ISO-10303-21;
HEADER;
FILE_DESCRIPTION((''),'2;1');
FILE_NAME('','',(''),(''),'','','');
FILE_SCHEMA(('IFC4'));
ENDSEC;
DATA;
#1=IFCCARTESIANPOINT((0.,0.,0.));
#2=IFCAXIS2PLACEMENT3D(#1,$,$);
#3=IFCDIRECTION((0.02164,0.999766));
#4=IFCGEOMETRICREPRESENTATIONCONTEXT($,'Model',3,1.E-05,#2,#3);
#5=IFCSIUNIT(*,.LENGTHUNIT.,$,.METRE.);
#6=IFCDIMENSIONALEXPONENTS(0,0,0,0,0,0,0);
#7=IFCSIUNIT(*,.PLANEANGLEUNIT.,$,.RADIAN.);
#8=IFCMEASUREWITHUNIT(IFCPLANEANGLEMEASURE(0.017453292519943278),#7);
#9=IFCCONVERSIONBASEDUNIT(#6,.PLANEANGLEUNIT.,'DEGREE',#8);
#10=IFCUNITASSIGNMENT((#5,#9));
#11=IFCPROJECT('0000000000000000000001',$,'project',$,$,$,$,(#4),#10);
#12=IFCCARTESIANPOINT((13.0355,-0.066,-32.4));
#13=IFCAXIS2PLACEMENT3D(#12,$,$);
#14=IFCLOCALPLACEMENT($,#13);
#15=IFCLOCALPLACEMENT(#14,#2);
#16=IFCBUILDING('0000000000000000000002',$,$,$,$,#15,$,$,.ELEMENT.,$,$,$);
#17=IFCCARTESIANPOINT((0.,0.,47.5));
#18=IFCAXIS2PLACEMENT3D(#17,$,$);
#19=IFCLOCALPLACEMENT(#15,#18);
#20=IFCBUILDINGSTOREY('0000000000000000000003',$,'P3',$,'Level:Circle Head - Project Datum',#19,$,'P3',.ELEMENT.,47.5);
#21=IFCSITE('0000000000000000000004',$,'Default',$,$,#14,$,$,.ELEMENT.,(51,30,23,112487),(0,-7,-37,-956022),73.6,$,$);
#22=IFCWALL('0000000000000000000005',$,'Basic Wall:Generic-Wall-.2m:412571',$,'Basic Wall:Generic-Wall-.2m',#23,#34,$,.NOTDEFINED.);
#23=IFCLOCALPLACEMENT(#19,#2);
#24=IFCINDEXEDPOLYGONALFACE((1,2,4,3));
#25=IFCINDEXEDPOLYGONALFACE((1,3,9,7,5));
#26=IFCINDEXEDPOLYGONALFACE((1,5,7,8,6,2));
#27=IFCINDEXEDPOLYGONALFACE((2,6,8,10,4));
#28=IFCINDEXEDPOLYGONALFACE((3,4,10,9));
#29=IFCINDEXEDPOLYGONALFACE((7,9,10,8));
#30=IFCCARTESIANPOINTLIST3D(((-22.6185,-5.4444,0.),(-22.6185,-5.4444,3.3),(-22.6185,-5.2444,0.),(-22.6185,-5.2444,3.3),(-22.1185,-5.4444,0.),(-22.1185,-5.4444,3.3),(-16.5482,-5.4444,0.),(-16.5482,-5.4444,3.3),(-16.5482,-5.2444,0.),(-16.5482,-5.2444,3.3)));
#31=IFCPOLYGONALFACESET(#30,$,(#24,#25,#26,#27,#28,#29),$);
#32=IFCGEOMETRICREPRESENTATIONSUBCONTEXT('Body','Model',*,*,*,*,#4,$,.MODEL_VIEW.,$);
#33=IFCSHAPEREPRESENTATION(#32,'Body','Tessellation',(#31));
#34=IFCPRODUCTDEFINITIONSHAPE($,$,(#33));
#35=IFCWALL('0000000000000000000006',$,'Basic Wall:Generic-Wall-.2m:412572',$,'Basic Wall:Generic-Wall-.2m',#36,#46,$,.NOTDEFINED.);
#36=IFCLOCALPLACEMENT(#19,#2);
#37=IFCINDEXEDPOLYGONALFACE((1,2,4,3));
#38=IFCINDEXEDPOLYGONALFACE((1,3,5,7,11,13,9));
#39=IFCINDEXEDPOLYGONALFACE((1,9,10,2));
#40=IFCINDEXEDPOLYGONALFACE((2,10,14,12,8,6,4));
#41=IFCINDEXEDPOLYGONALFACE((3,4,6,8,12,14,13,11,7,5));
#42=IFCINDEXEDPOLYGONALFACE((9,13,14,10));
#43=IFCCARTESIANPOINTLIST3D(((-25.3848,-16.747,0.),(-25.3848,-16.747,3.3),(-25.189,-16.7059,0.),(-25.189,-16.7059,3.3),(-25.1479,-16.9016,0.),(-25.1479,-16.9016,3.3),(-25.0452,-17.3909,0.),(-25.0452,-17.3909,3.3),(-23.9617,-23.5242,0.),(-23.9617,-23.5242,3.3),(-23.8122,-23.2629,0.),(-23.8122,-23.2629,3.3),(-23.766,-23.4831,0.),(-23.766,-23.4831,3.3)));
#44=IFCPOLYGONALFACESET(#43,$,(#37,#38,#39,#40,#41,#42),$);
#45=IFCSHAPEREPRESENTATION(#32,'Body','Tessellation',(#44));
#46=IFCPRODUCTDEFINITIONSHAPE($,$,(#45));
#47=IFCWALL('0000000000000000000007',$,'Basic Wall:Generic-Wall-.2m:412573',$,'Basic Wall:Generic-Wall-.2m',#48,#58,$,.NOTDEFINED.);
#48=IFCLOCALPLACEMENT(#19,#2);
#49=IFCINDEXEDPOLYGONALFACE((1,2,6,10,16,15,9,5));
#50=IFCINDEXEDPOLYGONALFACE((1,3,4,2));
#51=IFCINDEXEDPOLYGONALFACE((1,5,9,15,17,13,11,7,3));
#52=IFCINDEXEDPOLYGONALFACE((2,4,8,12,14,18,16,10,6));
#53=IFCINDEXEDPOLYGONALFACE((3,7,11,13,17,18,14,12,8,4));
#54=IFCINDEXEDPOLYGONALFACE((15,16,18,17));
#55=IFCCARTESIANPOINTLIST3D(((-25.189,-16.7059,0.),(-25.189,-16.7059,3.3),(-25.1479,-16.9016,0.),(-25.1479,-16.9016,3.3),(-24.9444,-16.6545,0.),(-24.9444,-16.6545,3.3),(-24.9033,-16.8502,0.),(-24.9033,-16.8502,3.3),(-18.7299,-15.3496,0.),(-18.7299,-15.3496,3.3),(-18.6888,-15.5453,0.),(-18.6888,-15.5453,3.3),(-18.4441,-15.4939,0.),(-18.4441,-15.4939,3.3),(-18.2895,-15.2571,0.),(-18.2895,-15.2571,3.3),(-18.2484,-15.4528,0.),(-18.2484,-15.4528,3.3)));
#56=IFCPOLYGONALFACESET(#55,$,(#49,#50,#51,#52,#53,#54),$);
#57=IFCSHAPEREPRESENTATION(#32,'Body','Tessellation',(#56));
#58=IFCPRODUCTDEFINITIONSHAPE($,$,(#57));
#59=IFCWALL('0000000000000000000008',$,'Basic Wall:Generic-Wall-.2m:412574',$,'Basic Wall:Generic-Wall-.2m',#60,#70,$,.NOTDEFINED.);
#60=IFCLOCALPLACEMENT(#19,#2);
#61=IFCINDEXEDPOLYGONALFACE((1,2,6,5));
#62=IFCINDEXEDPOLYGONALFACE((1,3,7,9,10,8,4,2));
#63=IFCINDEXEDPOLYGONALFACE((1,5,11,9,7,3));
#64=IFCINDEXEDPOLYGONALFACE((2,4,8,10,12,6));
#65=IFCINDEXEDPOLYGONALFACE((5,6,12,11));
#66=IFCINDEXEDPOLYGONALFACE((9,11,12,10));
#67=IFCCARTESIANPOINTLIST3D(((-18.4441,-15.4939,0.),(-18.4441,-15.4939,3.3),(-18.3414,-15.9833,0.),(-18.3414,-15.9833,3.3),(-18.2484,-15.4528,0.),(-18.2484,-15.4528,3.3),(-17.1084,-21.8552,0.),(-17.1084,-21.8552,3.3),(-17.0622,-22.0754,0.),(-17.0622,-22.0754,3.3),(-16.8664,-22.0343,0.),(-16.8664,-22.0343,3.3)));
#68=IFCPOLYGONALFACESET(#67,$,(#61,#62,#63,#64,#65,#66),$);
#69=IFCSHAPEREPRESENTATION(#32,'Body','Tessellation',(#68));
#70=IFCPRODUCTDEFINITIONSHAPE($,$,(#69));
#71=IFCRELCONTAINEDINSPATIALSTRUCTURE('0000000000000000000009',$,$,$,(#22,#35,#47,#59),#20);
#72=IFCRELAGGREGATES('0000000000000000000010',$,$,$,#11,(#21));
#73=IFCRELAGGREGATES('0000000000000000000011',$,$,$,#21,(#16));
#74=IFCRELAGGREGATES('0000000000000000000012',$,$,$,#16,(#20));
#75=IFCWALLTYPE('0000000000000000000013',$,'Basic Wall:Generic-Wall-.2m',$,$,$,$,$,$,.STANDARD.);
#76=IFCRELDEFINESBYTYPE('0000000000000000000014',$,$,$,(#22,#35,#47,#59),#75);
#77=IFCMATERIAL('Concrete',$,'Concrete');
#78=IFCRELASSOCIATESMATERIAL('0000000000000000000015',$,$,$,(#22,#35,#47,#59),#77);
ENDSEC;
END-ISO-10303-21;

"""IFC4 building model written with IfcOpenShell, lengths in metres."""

from ifc_helpers import new_model, entity, si_unit, converted_unit, direction, frame, origin, place, context, subcontext, project, spatial, indexed_curve, outline, extrude, material, type_object, element, save


model = new_model("IFC4")

# Units and contexts
model_context = context("Model", 3, precision=1e-05, world=origin(), true_north=direction((0.02164, 0.999766)))
body_context = subcontext(model_context, "Body", "Model", "MODEL_VIEW")
ifc_project = project(units=[si_unit("LENGTHUNIT", "METRE"), converted_unit("PLANEANGLEUNIT", "DEGREE", entity("IfcPlaneAngleMeasure", 0.017453292519943278), si_unit("PLANEANGLEUNIT", "RADIAN"), dimensions=[0, 0, 0, 0, 0, 0, 0])], contexts=[model_context])

# Site, building, storey
site_placement = place(None, frame((13.0355, -0.066, -32.4)))
site = spatial("IfcSite", under=ifc_project, at=site_placement, Name="Default", CompositionType="ELEMENT", RefLatitude=(51, 30, 23, 112487), RefLongitude=(0, -7, -37, -956022), RefElevation=73.6)
building_placement = place(site_placement, origin())
building = spatial("IfcBuilding", under=site, at=building_placement, CompositionType="ELEMENT")
storey_placement = place(building_placement, frame((0.0, 0.0, 47.5)))
storey = spatial("IfcBuildingStorey", under=building, at=storey_placement, Name="P3", ObjectType="Level:Circle Head - Project Datum", LongName="P3", CompositionType="ELEMENT", Elevation=47.5)

# Shared definitions
ifc_material = material(Name="Concrete", Category="Concrete")

# Walls
wall_type_1 = type_object("IfcWallType", Name="Basic Wall:Generic-Wall-.2m", PredefinedType="STANDARD")
wall_1_placement = place(storey_placement, frame((-22.6185, -5.3444, 0.0)))
element("IfcWall", 1, at=wall_1_placement, inside=storey, type_object=wall_type_1, material=ifc_material, Name="Basic Wall:Generic-Wall-.2m:412571", ObjectType="Basic Wall:Generic-Wall-.2m", PredefinedType="NOTDEFINED", context=body_context, shape_type="SweptSolid", body=[
    extrude(outline(indexed_curve([(6.0702, -0.1), (6.0702, 0.1), (0.0, 0.1), (0.0, -0.1), (0.5, -0.1), (6.0702, -0.1)], self_intersect=False)), origin(), (0.0, 0.0, 1.0), 3.3),
])
wall_2_placement = place(storey_placement, frame((-23.8638, -23.5036, 0.0), z_axis=(0.0, 0.0, 1.0), x_axis=(-0.2055, 0.978657, 0.0)))
element("IfcWall", 2, at=wall_2_placement, inside=storey, type_object=wall_type_1, material=ifc_material, Name="Basic Wall:Generic-Wall-.2m:412572", ObjectType="Basic Wall:Generic-Wall-.2m", PredefinedType="NOTDEFINED", context=body_context, shape_type="SweptSolid", body=[
    extrude(outline(indexed_curve([(6.925, -0.1), (6.925, 0.1), (0.0, 0.1), (0.0, -0.1), (0.225, -0.1), (6.225, -0.1), (6.725, -0.1), (6.925, -0.1)], self_intersect=False)), origin(), (0.0, 0.0, 1.0), 3.3),
])
wall_3_placement = place(storey_placement, frame((-25.1685, -16.8038, 0.0), z_axis=(0.0, 0.0, 1.0), x_axis=(0.978657, 0.2055, 0.0)))
element("IfcWall", 3, at=wall_3_placement, inside=storey, type_object=wall_type_1, material=ifc_material, Name="Basic Wall:Generic-Wall-.2m:412573", ObjectType="Basic Wall:Generic-Wall-.2m", PredefinedType="NOTDEFINED", context=body_context, shape_type="SweptSolid", body=[
    extrude(outline(indexed_curve([(7.05, -0.1), (7.05, 0.1), (6.6, 0.1), (0.25, 0.1), (0.0, 0.1), (0.0, -0.1), (0.25, -0.1), (6.6, -0.1), (6.85, -0.1), (7.05, -0.1)], self_intersect=False)), origin(), (0.0, 0.0, 1.0), 3.3),
])
wall_4_placement = place(storey_placement, frame((-18.3463, -15.4734, 0.0), z_axis=(0.0, 0.0, 1.0), x_axis=(0.2055, -0.978657, 0.0)))
element("IfcWall", 4, at=wall_4_placement, inside=storey, type_object=wall_type_1, material=ifc_material, Name="Basic Wall:Generic-Wall-.2m:412574", ObjectType="Basic Wall:Generic-Wall-.2m", PredefinedType="NOTDEFINED", context=body_context, shape_type="SweptSolid", body=[
    extrude(outline(indexed_curve([(6.725, -0.1), (6.725, 0.1), (0.0, 0.1), (0.0, -0.1), (0.5, -0.1), (6.5, -0.1), (6.725, -0.1)], self_intersect=False)), origin(), (0.0, 0.0, 1.0), 3.3),
])

save(model, "model.ifc")
